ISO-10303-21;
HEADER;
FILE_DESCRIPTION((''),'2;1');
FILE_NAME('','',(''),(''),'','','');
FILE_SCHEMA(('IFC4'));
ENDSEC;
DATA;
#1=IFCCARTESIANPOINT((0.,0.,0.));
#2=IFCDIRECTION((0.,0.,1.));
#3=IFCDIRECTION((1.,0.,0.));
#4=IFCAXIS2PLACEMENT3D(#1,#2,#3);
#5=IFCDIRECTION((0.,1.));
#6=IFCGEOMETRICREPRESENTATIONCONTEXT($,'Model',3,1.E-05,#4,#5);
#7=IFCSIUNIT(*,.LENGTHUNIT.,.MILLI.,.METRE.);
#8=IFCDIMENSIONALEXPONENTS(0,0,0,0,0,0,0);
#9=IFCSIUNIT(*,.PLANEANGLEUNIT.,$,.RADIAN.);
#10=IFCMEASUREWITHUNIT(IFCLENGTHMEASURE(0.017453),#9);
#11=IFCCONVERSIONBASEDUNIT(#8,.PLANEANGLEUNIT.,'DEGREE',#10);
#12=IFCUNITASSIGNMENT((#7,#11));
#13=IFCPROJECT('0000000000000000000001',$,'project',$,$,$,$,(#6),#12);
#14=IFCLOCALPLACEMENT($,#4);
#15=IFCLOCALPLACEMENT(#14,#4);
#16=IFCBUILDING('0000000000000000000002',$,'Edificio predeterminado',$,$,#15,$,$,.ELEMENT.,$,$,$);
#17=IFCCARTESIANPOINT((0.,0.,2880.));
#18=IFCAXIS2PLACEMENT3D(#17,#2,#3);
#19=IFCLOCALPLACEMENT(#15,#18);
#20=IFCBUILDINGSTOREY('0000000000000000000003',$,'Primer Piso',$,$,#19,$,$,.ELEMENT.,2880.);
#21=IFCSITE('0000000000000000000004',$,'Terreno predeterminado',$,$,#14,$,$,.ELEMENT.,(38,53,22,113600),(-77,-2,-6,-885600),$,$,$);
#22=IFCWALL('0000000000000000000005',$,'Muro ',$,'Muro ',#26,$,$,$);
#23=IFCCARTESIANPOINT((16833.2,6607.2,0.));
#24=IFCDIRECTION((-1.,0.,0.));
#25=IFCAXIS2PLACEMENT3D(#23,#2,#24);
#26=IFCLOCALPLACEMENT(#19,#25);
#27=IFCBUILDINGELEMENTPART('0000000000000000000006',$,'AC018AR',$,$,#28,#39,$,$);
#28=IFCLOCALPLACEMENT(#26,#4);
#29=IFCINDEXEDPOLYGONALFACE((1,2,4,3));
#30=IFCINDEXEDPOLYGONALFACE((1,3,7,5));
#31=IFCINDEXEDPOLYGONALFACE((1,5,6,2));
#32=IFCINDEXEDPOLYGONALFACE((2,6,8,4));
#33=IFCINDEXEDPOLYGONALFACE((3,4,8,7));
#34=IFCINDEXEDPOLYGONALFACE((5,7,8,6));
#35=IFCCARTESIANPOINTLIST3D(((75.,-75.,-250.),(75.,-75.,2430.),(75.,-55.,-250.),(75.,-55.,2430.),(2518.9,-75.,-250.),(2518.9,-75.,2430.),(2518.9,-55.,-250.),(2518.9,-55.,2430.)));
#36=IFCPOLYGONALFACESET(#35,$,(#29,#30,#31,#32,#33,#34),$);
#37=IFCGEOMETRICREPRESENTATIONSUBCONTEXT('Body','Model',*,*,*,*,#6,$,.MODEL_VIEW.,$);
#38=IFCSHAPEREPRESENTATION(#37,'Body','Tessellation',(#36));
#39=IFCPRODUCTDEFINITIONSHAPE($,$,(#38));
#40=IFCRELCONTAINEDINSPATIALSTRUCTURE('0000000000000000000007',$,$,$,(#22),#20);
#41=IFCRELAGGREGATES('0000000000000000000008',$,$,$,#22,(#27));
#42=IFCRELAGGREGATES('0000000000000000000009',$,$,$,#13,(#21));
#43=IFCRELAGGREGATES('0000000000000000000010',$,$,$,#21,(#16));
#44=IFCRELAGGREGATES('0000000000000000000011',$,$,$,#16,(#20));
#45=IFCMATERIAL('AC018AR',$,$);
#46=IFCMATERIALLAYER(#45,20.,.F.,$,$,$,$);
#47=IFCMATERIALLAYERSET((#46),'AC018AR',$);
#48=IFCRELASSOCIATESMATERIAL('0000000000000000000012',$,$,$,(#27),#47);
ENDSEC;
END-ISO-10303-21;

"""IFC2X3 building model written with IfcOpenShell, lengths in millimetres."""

from ifc_helpers import new_model, entity, si_unit, converted_unit, direction, frame, origin_with_axes, place, context, subcontext, project, spatial, polyline, outline, extrude, material, layer, layer_set, layer_usage, element, aggregate, save


model = new_model("IFC2X3")

# Units and contexts
model_context = context("Model", 3, precision=1e-05, world=origin_with_axes(), true_north=direction((0.0, 1.0)))
body_context = subcontext(model_context, "Body", "Model", "MODEL_VIEW")
ifc_project = project(units=[si_unit("LENGTHUNIT", "METRE", prefix="MILLI"), converted_unit("PLANEANGLEUNIT", "DEGREE", entity("IfcLengthMeasure", 0.017453), si_unit("PLANEANGLEUNIT", "RADIAN"), dimensions=[0, 0, 0, 0, 0, 0, 0])], contexts=[model_context])

# Site, building, storey
site_placement = place(None, origin_with_axes())
site = spatial("IfcSite", under=ifc_project, at=site_placement, Name="Terreno predeterminado", CompositionType="ELEMENT", RefLatitude=(38, 53, 22, 113600), RefLongitude=(-77, -2, -6, -885600))
building_placement = place(site_placement, origin_with_axes())
building = spatial("IfcBuilding", under=site, at=building_placement, Name="Edificio predeterminado", CompositionType="ELEMENT")
storey_placement = place(building_placement, frame((0.0, 0.0, 2880.0), z_axis=(0.0, 0.0, 1.0), x_axis=(1.0, 0.0, 0.0)))
storey = spatial("IfcBuildingStorey", under=building, at=storey_placement, Name="Primer Piso", CompositionType="ELEMENT", Elevation=2880.0)

# Wall, building element part
wall_1_placement = place(storey_placement, frame((16833.2, 6607.2, 0.0), z_axis=(0.0, 0.0, 1.0), x_axis=(-1.0, 0.0, 0.0)))
wall_1 = element("IfcWall", 1, at=wall_1_placement, inside=storey, Name="Muro ", ObjectType="Muro ")
ifc_material_1 = material(Name="AC018AR")
ifc_layer_1 = layer(ifc_material_1, 20.0, ventilated=False)
ifc_layer_set_1 = layer_set([ifc_layer_1], Name="AC018AR")
ifc_layer_usage_1 = layer_usage(ifc_layer_set_1, "AXIS2", "NEGATIVE", 55.0)
building_element_part_1_placement = place(wall_1_placement, origin_with_axes())
building_element_part_1 = element("IfcBuildingElementPart", 2, at=building_element_part_1_placement, material=ifc_layer_usage_1, Name="AC018AR", context=body_context, shape_type="SweptSolid", body=[
    extrude(outline(polyline([(2518.9, -55.0), (2518.9, -75.0), (75.0, -75.0), (75.0, -55.0), (2518.9, -55.0)])), frame((0.0, 0.0, -250.0), z_axis=(0.0, 0.0, 1.0), x_axis=(1.0, 0.0, 0.0)), (0.0, 0.0, 1.0), 2680.0),
])
aggregate(wall_1, [building_element_part_1])

save(model, "model.ifc")
